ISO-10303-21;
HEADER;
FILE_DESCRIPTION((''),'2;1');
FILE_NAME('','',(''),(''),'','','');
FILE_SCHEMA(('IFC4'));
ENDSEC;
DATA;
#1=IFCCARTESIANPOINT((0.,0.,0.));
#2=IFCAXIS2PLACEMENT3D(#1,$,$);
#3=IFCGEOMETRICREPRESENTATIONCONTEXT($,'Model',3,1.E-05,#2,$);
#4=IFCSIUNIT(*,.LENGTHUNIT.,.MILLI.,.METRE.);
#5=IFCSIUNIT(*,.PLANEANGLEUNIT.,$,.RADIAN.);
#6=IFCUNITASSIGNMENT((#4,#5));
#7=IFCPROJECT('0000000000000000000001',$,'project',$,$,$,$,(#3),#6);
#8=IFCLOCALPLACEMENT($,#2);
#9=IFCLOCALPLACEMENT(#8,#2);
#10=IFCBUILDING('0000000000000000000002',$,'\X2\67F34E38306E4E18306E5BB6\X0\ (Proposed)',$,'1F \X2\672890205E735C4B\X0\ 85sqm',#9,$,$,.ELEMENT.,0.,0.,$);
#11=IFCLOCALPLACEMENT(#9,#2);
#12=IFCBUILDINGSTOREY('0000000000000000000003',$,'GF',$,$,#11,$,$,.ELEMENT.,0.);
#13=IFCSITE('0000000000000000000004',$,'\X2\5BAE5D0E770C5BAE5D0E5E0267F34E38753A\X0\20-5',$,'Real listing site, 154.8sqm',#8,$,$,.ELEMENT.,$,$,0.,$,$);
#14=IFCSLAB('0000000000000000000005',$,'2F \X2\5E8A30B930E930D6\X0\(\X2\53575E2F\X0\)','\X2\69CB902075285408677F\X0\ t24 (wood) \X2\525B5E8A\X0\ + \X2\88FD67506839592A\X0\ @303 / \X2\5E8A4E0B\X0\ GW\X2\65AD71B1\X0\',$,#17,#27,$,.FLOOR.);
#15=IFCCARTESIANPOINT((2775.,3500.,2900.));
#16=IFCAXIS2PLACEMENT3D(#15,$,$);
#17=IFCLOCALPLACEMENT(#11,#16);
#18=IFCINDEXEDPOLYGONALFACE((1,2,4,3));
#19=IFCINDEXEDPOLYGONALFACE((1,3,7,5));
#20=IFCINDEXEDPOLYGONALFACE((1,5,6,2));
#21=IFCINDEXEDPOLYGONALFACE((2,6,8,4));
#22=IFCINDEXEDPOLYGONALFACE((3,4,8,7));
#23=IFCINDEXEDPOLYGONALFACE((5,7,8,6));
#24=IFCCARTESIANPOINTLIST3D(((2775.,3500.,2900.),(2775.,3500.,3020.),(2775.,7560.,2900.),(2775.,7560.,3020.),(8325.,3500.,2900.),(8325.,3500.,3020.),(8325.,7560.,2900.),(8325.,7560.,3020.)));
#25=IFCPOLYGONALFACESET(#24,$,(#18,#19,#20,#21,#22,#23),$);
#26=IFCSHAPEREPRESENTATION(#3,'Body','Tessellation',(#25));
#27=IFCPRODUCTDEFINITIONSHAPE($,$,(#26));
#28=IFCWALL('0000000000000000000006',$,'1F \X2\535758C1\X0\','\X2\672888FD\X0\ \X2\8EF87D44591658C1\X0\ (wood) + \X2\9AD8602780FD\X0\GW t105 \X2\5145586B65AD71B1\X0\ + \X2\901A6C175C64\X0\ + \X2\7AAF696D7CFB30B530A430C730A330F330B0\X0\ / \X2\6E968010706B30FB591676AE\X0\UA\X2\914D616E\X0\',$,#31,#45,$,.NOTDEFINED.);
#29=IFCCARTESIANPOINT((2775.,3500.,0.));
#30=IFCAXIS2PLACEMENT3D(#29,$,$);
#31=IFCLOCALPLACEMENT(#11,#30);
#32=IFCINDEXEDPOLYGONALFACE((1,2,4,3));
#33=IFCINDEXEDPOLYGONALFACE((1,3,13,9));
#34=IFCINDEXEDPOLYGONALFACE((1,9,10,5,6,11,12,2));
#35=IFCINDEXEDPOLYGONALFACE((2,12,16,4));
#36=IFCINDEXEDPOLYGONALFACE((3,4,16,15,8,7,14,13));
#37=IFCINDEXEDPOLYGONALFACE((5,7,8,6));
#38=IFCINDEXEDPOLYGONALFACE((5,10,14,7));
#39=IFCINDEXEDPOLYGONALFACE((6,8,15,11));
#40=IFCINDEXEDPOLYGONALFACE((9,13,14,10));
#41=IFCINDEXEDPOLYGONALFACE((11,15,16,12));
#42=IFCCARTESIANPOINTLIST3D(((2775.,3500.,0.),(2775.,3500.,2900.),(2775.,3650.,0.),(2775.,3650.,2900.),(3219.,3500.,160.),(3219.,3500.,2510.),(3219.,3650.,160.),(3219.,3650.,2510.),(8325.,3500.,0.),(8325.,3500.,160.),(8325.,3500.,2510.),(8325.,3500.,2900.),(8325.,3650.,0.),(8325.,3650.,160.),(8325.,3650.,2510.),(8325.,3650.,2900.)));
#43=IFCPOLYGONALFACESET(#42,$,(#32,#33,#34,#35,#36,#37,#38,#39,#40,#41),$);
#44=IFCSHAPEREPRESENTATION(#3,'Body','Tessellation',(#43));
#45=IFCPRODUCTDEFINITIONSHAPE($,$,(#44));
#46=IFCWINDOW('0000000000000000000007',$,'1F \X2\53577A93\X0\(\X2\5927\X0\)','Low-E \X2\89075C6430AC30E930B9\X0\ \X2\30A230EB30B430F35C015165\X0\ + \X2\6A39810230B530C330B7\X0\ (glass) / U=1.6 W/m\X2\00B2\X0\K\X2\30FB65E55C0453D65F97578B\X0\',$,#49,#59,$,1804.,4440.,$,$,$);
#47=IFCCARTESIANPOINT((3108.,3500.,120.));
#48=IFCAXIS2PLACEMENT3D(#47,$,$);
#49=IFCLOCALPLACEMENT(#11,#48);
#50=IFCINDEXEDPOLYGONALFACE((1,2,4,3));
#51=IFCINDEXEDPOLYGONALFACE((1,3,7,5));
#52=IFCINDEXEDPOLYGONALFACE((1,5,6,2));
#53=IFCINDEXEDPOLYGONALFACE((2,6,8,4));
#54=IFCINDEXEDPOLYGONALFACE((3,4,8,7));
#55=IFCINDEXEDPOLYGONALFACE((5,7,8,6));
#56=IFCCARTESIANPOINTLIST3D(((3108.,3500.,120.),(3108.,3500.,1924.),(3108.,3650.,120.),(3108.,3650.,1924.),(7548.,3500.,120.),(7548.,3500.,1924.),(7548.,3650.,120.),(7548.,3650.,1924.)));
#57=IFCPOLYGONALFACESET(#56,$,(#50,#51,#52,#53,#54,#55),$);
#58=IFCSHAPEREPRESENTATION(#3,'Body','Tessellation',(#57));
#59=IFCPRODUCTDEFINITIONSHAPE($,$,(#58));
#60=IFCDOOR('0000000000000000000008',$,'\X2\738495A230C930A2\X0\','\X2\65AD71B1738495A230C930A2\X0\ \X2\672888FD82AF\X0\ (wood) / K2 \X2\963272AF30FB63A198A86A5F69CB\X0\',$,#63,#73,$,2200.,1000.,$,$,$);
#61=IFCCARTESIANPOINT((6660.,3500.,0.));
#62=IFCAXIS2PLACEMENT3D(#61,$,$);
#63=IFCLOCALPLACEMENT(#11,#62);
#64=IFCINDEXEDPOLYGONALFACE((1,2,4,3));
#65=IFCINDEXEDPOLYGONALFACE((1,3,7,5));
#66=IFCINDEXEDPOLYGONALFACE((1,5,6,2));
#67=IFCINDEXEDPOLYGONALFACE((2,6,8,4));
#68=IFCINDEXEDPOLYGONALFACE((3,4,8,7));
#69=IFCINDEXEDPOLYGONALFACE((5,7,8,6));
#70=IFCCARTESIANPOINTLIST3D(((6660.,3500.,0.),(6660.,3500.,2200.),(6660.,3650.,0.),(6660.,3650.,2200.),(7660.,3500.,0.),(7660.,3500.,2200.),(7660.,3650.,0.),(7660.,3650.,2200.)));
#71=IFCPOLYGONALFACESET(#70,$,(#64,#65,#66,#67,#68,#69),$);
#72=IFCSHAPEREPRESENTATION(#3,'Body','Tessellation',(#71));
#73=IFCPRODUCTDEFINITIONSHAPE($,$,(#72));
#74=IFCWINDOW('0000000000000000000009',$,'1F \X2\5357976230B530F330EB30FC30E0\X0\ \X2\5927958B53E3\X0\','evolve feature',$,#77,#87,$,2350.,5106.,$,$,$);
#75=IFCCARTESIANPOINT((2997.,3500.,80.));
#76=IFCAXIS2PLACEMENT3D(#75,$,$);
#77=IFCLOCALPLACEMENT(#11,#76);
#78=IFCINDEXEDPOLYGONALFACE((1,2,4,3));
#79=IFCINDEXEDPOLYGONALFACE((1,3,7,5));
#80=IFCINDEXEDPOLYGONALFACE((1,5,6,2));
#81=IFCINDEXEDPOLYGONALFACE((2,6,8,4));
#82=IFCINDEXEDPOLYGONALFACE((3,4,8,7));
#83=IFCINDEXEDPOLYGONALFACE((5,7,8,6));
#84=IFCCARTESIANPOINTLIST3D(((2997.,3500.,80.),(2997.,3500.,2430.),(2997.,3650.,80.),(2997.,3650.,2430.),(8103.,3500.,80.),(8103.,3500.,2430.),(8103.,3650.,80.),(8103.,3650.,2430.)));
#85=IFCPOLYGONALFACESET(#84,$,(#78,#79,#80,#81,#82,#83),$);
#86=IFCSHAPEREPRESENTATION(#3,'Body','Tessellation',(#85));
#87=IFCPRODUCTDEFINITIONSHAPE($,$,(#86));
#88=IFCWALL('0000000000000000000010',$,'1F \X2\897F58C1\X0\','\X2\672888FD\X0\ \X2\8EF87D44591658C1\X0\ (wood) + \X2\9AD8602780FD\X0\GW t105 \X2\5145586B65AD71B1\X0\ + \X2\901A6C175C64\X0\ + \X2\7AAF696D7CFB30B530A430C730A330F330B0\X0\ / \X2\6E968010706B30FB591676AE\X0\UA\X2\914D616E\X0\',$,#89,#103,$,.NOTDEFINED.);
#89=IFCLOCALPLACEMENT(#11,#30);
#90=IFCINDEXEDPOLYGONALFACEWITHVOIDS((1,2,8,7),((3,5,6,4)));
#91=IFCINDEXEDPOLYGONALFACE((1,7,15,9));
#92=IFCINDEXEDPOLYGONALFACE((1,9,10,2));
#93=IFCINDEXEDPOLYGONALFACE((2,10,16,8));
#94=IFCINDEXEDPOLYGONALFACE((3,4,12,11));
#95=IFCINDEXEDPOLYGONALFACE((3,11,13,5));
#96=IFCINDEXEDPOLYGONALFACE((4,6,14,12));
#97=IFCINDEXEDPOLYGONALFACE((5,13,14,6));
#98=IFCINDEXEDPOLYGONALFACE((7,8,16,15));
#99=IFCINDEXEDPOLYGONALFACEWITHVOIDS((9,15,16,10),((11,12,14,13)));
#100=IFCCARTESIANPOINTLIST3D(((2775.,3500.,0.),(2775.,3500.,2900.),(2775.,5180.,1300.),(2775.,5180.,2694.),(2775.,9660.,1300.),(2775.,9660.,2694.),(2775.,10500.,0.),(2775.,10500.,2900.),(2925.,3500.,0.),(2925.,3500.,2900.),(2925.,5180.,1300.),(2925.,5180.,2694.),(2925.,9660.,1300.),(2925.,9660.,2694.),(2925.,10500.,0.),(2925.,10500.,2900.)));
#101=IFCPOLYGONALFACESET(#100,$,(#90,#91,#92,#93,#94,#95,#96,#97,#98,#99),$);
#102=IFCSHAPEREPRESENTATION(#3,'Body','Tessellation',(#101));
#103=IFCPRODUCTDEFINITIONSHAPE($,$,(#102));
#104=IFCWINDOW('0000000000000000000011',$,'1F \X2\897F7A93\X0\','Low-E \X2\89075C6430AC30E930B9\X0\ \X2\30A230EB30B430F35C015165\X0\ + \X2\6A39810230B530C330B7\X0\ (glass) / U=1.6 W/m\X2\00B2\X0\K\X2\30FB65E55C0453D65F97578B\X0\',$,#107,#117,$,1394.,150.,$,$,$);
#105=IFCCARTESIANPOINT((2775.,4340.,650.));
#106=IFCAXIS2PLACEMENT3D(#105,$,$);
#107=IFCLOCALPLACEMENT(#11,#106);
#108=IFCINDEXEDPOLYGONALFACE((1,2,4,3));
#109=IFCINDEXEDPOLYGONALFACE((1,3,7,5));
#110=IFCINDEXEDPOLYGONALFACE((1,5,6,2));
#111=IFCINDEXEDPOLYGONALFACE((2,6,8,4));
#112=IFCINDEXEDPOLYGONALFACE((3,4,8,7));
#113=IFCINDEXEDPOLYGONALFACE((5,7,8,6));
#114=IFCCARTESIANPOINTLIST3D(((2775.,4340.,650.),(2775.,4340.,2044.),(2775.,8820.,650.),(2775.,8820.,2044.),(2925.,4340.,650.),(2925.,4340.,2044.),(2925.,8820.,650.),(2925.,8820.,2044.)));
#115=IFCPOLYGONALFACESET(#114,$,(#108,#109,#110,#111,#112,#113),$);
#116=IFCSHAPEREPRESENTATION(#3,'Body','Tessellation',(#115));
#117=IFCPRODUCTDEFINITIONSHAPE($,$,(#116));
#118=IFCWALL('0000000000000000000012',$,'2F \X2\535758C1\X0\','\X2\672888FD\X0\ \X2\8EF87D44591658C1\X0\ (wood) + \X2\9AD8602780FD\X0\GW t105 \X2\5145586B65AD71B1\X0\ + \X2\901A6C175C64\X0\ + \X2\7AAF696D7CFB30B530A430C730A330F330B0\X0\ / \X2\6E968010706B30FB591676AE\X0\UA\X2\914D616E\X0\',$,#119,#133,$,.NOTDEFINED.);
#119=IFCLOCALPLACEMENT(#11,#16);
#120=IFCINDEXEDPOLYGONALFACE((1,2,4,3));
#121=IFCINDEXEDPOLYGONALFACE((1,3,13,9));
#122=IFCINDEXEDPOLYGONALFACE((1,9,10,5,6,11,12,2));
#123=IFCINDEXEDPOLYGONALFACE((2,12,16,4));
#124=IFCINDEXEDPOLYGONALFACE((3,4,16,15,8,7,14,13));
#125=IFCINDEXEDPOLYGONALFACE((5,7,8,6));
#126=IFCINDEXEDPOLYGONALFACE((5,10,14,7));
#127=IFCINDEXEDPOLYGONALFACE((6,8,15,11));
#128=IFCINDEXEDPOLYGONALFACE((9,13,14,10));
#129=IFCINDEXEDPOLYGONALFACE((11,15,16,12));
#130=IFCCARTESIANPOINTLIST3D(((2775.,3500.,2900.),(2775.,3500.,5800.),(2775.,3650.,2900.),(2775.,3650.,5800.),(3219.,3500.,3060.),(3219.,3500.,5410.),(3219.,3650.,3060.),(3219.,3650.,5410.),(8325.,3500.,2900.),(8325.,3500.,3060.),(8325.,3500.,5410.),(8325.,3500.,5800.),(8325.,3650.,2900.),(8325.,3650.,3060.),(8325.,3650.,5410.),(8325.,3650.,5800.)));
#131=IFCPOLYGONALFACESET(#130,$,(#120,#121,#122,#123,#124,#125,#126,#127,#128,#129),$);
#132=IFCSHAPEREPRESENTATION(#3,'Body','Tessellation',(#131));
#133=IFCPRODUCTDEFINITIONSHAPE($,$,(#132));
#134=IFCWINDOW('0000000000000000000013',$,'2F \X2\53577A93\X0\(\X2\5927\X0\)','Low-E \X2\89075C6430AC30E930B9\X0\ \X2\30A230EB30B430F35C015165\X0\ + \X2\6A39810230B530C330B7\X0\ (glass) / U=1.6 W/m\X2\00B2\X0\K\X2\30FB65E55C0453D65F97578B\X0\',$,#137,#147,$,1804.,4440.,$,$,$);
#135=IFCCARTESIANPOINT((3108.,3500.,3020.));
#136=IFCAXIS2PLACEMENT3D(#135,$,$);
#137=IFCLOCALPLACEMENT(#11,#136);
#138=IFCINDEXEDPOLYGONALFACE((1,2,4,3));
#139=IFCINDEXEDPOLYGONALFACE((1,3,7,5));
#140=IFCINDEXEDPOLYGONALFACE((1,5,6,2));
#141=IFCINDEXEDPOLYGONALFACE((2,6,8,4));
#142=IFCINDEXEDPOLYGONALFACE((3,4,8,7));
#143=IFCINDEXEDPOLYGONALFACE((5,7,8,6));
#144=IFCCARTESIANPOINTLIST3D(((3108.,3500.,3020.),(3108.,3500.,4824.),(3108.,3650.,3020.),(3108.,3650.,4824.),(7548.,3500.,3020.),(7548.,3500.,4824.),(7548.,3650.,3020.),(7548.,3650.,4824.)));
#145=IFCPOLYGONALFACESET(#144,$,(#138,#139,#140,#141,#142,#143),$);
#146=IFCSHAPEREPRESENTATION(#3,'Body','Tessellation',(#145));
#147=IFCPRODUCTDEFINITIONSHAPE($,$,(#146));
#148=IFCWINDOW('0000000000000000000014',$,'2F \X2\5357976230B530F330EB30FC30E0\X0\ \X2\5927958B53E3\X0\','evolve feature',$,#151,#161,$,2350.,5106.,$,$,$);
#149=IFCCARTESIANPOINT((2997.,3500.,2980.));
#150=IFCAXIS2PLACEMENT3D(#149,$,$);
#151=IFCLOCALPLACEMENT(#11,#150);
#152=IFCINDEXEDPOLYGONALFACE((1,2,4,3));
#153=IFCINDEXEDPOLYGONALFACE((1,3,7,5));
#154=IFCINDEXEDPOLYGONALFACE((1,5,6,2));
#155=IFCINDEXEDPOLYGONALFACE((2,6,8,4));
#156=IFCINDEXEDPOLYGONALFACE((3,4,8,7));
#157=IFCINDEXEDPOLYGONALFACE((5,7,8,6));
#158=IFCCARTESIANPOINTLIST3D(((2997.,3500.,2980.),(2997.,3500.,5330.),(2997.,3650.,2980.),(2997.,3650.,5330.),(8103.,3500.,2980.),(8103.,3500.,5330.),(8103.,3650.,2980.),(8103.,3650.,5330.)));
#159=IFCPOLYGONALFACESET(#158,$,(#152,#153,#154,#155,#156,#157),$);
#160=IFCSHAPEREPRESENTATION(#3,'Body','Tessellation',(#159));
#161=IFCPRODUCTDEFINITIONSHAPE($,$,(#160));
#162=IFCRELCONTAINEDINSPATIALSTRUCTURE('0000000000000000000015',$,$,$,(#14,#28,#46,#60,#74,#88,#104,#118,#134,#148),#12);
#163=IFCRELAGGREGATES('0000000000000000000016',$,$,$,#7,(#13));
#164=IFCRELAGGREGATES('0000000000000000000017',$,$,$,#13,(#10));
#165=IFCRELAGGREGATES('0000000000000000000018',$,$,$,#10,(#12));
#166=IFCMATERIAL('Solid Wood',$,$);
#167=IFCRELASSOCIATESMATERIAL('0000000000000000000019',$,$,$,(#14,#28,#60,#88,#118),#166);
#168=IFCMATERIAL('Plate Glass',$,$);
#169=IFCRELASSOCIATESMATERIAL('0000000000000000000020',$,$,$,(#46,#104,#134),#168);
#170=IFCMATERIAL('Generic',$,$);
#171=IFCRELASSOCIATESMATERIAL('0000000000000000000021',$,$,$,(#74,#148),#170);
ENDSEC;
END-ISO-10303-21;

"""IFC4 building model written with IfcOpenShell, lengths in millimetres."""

from ifc_helpers import new_model, si_unit, frame, frame_2d, origin, place, context, project, spatial, rectangle, extrude, material, element, fill, save


model = new_model("IFC4")

# Units and contexts
model_context = context("Model", 3, precision=1e-05, world=origin())
ifc_project = project(units=[si_unit("LENGTHUNIT", "METRE", prefix="MILLI"), si_unit("PLANEANGLEUNIT", "RADIAN")], contexts=[model_context])

# Site, building, storey
site_placement = place(None, origin())
site = spatial("IfcSite", under=ifc_project, at=site_placement, Name="宮崎県宮崎市柳丸町20-5", ObjectType="Real listing site, 154.8sqm", CompositionType="ELEMENT", RefElevation=0.0)
building_placement = place(site_placement, origin())
building = spatial("IfcBuilding", under=site, at=building_placement, Name="柳丸の丘の家 (Proposed)", ObjectType="1F 木造平屋 85sqm", CompositionType="ELEMENT", ElevationOfRefHeight=0.0, ElevationOfTerrain=0.0)
storey_placement = place(building_placement, origin())
storey = spatial("IfcBuildingStorey", under=building, at=storey_placement, Name="GF", CompositionType="ELEMENT", Elevation=0.0)

# Slab
ifc_material_1 = material(Name="Solid Wood")
slab_1_placement = place(storey_placement, frame((2775.0, 3500.0, 2900.0)))
element("IfcSlab", 1, at=slab_1_placement, inside=storey, material=ifc_material_1, Name="2F 床スラブ(南帯)", Description="構造用合板 t24 (wood) 剛床 + 製材根太 @303 / 床下 GW断熱", PredefinedType="FLOOR", context=model_context, shape_type="SweptSolid", body=[
    extrude(rectangle(XDim=5550.0, YDim=4060.0, at=frame_2d((2775.0, 2030.0))), frame((2775.0, 3500.0, 2900.0)), (0.0, 0.0, 1.0), 120.0),
])
ifc_material_2 = material(Name="Generic")

# Wall, openings, windows, door
wall_1_placement = place(storey_placement, frame((2775.0, 3500.0, 0.0)))
wall_1 = element("IfcWall", 2, at=wall_1_placement, inside=storey, material=ifc_material_1, Name="1F 南壁", Description="木製 軸組外壁 (wood) + 高性能GW t105 充填断熱 + 通気層 + 窯業系サイディング / 準耐火・外皮UA配慮", PredefinedType="NOTDEFINED", context=model_context, shape_type="SweptSolid", body=[
    extrude(rectangle(XDim=5550.0, YDim=150.0, at=frame_2d((2775.0, 75.0))), frame((2775.0, 3500.0, 0.0)), (0.0, 0.0, 1.0), 2900.0),
])
opening_1_placement = place(storey_placement, frame((3108.0, 3500.0, 120.0)))
opening_1 = element("IfcOpeningElement", 3, at=opening_1_placement, cuts=wall_1, PredefinedType="NOTDEFINED", context=model_context, shape_type="SweptSolid", body=[
    extrude(rectangle(XDim=4440.0, YDim=150.0, at=frame_2d((2220.0, 75.0))), frame((3108.0, 3500.0, 120.0)), (0.0, 0.0, 1.0), 1804.0),
])
opening_2_placement = place(storey_placement, frame((6660.0, 3500.0, 0.0)))
opening_2 = element("IfcOpeningElement", 4, at=opening_2_placement, cuts=wall_1, PredefinedType="NOTDEFINED", context=model_context, shape_type="SweptSolid", body=[
    extrude(rectangle(XDim=1000.0, YDim=150.0, at=frame_2d((500.0, 75.0))), frame((6660.0, 3500.0, 0.0)), (0.0, 0.0, 1.0), 2200.0),
])
opening_3_placement = place(storey_placement, frame((2997.0, 3500.0, 80.0)))
opening_3 = element("IfcOpeningElement", 5, at=opening_3_placement, cuts=wall_1, PredefinedType="NOTDEFINED", context=model_context, shape_type="SweptSolid", body=[
    extrude(rectangle(XDim=5106.0, YDim=150.0, at=frame_2d((2553.0, 75.0))), frame((2997.0, 3500.0, 80.0)), (0.0, 0.0, 1.0), 2350.0),
])
ifc_material_3 = material(Name="Plate Glass")
window_1_placement = place(storey_placement, frame((3108.0, 3500.0, 120.0)))
window_1 = element("IfcWindow", 6, at=window_1_placement, inside=storey, material=ifc_material_3, Name="1F 南窓(大)", Description="Low-E 複層ガラス アルゴン封入 + 樹脂サッシ (glass) / U=1.6 W/m²K・日射取得型", OverallHeight=1804.0, OverallWidth=4440.0, context=model_context, shape_type="SweptSolid", body=[
    extrude(rectangle(XDim=4440.0, YDim=150.0, at=frame_2d((2220.0, 75.0))), frame((3108.0, 3500.0, 120.0)), (0.0, 0.0, 1.0), 1804.0),
])
fill(opening_1, window_1)
door_placement = place(storey_placement, frame((6660.0, 3500.0, 0.0)))
door = element("IfcDoor", 7, at=door_placement, inside=storey, material=ifc_material_1, Name="玄関ドア", Description="断熱玄関ドア 木製芯 (wood) / K2 防犯・採風機構", OverallHeight=2200.0, OverallWidth=1000.0, context=model_context, shape_type="SweptSolid", body=[
    extrude(rectangle(XDim=1000.0, YDim=150.0, at=frame_2d((500.0, 75.0))), frame((6660.0, 3500.0, 0.0)), (0.0, 0.0, 1.0), 2200.0),
])
fill(opening_2, door)
window_2_placement = place(storey_placement, frame((2997.0, 3500.0, 80.0)))
window_2 = element("IfcWindow", 8, at=window_2_placement, inside=storey, material=ifc_material_2, Name="1F 南面サンルーム 大開口", Description="evolve feature", OverallHeight=2350.0, OverallWidth=5106.0, context=model_context, shape_type="SweptSolid", body=[
    extrude(rectangle(XDim=5106.0, YDim=150.0, at=frame_2d((2553.0, 75.0))), frame((2997.0, 3500.0, 80.0)), (0.0, 0.0, 1.0), 2350.0),
])
fill(opening_3, window_2)

# Wall, opening, window
wall_2_placement = place(storey_placement, frame((2775.0, 3500.0, 0.0)))
wall_2 = element("IfcWall", 9, at=wall_2_placement, inside=storey, material=ifc_material_1, Name="1F 西壁", Description="木製 軸組外壁 (wood) + 高性能GW t105 充填断熱 + 通気層 + 窯業系サイディング / 準耐火・外皮UA配慮", PredefinedType="NOTDEFINED", context=model_context, shape_type="SweptSolid", body=[
    extrude(rectangle(XDim=150.0, YDim=7000.0, at=frame_2d((75.0, 3500.0))), frame((2775.0, 3500.0, 0.0)), (0.0, 0.0, 1.0), 2900.0),
])
opening_4_placement = place(storey_placement, frame((2775.0, 4340.0, 650.0)))
opening_4 = element("IfcOpeningElement", 10, at=opening_4_placement, cuts=wall_2, PredefinedType="NOTDEFINED", context=model_context, shape_type="SweptSolid", body=[
    extrude(rectangle(XDim=150.0, YDim=4480.0, at=frame_2d((75.0, 2240.0))), frame((2775.0, 4340.0, 650.0)), (0.0, 0.0, 1.0), 1394.0),
])
window_3_placement = place(storey_placement, frame((2775.0, 4340.0, 650.0)))
window_3 = element("IfcWindow", 11, at=window_3_placement, inside=storey, material=ifc_material_3, Name="1F 西窓", Description="Low-E 複層ガラス アルゴン封入 + 樹脂サッシ (glass) / U=1.6 W/m²K・日射取得型", OverallHeight=1394.0, OverallWidth=150.0, context=model_context, shape_type="SweptSolid", body=[
    extrude(rectangle(XDim=150.0, YDim=4480.0, at=frame_2d((75.0, 2240.0))), frame((2775.0, 4340.0, 650.0)), (0.0, 0.0, 1.0), 1394.0),
])
fill(opening_4, window_3)

# Wall, openings, windows
wall_3_placement = place(storey_placement, frame((2775.0, 3500.0, 2900.0)))
wall_3 = element("IfcWall", 12, at=wall_3_placement, inside=storey, material=ifc_material_1, Name="2F 南壁", Description="木製 軸組外壁 (wood) + 高性能GW t105 充填断熱 + 通気層 + 窯業系サイディング / 準耐火・外皮UA配慮", PredefinedType="NOTDEFINED", context=model_context, shape_type="SweptSolid", body=[
    extrude(rectangle(XDim=5550.0, YDim=150.0, at=frame_2d((2775.0, 75.0))), frame((2775.0, 3500.0, 2900.0)), (0.0, 0.0, 1.0), 2900.0),
])
opening_5_placement = place(storey_placement, frame((3108.0, 3500.0, 3020.0)))
opening_5 = element("IfcOpeningElement", 13, at=opening_5_placement, cuts=wall_3, PredefinedType="NOTDEFINED", context=model_context, shape_type="SweptSolid", body=[
    extrude(rectangle(XDim=4440.0, YDim=150.0, at=frame_2d((2220.0, 75.0))), frame((3108.0, 3500.0, 3020.0)), (0.0, 0.0, 1.0), 1804.0),
])
opening_6_placement = place(storey_placement, frame((2997.0, 3500.0, 2980.0)))
opening_6 = element("IfcOpeningElement", 14, at=opening_6_placement, cuts=wall_3, PredefinedType="NOTDEFINED", context=model_context, shape_type="SweptSolid", body=[
    extrude(rectangle(XDim=5106.0, YDim=150.0, at=frame_2d((2553.0, 75.0))), frame((2997.0, 3500.0, 2980.0)), (0.0, 0.0, 1.0), 2350.0),
])
window_4_placement = place(storey_placement, frame((3108.0, 3500.0, 3020.0)))
window_4 = element("IfcWindow", 15, at=window_4_placement, inside=storey, material=ifc_material_3, Name="2F 南窓(大)", Description="Low-E 複層ガラス アルゴン封入 + 樹脂サッシ (glass) / U=1.6 W/m²K・日射取得型", OverallHeight=1804.0, OverallWidth=4440.0, context=model_context, shape_type="SweptSolid", body=[
    extrude(rectangle(XDim=4440.0, YDim=150.0, at=frame_2d((2220.0, 75.0))), frame((3108.0, 3500.0, 3020.0)), (0.0, 0.0, 1.0), 1804.0),
])
fill(opening_5, window_4)
window_5_placement = place(storey_placement, frame((2997.0, 3500.0, 2980.0)))
window_5 = element("IfcWindow", 16, at=window_5_placement, inside=storey, material=ifc_material_2, Name="2F 南面サンルーム 大開口", Description="evolve feature", OverallHeight=2350.0, OverallWidth=5106.0, context=model_context, shape_type="SweptSolid", body=[
    extrude(rectangle(XDim=5106.0, YDim=150.0, at=frame_2d((2553.0, 75.0))), frame((2997.0, 3500.0, 2980.0)), (0.0, 0.0, 1.0), 2350.0),
])
fill(opening_6, window_5)

save(model, "model.ifc")
